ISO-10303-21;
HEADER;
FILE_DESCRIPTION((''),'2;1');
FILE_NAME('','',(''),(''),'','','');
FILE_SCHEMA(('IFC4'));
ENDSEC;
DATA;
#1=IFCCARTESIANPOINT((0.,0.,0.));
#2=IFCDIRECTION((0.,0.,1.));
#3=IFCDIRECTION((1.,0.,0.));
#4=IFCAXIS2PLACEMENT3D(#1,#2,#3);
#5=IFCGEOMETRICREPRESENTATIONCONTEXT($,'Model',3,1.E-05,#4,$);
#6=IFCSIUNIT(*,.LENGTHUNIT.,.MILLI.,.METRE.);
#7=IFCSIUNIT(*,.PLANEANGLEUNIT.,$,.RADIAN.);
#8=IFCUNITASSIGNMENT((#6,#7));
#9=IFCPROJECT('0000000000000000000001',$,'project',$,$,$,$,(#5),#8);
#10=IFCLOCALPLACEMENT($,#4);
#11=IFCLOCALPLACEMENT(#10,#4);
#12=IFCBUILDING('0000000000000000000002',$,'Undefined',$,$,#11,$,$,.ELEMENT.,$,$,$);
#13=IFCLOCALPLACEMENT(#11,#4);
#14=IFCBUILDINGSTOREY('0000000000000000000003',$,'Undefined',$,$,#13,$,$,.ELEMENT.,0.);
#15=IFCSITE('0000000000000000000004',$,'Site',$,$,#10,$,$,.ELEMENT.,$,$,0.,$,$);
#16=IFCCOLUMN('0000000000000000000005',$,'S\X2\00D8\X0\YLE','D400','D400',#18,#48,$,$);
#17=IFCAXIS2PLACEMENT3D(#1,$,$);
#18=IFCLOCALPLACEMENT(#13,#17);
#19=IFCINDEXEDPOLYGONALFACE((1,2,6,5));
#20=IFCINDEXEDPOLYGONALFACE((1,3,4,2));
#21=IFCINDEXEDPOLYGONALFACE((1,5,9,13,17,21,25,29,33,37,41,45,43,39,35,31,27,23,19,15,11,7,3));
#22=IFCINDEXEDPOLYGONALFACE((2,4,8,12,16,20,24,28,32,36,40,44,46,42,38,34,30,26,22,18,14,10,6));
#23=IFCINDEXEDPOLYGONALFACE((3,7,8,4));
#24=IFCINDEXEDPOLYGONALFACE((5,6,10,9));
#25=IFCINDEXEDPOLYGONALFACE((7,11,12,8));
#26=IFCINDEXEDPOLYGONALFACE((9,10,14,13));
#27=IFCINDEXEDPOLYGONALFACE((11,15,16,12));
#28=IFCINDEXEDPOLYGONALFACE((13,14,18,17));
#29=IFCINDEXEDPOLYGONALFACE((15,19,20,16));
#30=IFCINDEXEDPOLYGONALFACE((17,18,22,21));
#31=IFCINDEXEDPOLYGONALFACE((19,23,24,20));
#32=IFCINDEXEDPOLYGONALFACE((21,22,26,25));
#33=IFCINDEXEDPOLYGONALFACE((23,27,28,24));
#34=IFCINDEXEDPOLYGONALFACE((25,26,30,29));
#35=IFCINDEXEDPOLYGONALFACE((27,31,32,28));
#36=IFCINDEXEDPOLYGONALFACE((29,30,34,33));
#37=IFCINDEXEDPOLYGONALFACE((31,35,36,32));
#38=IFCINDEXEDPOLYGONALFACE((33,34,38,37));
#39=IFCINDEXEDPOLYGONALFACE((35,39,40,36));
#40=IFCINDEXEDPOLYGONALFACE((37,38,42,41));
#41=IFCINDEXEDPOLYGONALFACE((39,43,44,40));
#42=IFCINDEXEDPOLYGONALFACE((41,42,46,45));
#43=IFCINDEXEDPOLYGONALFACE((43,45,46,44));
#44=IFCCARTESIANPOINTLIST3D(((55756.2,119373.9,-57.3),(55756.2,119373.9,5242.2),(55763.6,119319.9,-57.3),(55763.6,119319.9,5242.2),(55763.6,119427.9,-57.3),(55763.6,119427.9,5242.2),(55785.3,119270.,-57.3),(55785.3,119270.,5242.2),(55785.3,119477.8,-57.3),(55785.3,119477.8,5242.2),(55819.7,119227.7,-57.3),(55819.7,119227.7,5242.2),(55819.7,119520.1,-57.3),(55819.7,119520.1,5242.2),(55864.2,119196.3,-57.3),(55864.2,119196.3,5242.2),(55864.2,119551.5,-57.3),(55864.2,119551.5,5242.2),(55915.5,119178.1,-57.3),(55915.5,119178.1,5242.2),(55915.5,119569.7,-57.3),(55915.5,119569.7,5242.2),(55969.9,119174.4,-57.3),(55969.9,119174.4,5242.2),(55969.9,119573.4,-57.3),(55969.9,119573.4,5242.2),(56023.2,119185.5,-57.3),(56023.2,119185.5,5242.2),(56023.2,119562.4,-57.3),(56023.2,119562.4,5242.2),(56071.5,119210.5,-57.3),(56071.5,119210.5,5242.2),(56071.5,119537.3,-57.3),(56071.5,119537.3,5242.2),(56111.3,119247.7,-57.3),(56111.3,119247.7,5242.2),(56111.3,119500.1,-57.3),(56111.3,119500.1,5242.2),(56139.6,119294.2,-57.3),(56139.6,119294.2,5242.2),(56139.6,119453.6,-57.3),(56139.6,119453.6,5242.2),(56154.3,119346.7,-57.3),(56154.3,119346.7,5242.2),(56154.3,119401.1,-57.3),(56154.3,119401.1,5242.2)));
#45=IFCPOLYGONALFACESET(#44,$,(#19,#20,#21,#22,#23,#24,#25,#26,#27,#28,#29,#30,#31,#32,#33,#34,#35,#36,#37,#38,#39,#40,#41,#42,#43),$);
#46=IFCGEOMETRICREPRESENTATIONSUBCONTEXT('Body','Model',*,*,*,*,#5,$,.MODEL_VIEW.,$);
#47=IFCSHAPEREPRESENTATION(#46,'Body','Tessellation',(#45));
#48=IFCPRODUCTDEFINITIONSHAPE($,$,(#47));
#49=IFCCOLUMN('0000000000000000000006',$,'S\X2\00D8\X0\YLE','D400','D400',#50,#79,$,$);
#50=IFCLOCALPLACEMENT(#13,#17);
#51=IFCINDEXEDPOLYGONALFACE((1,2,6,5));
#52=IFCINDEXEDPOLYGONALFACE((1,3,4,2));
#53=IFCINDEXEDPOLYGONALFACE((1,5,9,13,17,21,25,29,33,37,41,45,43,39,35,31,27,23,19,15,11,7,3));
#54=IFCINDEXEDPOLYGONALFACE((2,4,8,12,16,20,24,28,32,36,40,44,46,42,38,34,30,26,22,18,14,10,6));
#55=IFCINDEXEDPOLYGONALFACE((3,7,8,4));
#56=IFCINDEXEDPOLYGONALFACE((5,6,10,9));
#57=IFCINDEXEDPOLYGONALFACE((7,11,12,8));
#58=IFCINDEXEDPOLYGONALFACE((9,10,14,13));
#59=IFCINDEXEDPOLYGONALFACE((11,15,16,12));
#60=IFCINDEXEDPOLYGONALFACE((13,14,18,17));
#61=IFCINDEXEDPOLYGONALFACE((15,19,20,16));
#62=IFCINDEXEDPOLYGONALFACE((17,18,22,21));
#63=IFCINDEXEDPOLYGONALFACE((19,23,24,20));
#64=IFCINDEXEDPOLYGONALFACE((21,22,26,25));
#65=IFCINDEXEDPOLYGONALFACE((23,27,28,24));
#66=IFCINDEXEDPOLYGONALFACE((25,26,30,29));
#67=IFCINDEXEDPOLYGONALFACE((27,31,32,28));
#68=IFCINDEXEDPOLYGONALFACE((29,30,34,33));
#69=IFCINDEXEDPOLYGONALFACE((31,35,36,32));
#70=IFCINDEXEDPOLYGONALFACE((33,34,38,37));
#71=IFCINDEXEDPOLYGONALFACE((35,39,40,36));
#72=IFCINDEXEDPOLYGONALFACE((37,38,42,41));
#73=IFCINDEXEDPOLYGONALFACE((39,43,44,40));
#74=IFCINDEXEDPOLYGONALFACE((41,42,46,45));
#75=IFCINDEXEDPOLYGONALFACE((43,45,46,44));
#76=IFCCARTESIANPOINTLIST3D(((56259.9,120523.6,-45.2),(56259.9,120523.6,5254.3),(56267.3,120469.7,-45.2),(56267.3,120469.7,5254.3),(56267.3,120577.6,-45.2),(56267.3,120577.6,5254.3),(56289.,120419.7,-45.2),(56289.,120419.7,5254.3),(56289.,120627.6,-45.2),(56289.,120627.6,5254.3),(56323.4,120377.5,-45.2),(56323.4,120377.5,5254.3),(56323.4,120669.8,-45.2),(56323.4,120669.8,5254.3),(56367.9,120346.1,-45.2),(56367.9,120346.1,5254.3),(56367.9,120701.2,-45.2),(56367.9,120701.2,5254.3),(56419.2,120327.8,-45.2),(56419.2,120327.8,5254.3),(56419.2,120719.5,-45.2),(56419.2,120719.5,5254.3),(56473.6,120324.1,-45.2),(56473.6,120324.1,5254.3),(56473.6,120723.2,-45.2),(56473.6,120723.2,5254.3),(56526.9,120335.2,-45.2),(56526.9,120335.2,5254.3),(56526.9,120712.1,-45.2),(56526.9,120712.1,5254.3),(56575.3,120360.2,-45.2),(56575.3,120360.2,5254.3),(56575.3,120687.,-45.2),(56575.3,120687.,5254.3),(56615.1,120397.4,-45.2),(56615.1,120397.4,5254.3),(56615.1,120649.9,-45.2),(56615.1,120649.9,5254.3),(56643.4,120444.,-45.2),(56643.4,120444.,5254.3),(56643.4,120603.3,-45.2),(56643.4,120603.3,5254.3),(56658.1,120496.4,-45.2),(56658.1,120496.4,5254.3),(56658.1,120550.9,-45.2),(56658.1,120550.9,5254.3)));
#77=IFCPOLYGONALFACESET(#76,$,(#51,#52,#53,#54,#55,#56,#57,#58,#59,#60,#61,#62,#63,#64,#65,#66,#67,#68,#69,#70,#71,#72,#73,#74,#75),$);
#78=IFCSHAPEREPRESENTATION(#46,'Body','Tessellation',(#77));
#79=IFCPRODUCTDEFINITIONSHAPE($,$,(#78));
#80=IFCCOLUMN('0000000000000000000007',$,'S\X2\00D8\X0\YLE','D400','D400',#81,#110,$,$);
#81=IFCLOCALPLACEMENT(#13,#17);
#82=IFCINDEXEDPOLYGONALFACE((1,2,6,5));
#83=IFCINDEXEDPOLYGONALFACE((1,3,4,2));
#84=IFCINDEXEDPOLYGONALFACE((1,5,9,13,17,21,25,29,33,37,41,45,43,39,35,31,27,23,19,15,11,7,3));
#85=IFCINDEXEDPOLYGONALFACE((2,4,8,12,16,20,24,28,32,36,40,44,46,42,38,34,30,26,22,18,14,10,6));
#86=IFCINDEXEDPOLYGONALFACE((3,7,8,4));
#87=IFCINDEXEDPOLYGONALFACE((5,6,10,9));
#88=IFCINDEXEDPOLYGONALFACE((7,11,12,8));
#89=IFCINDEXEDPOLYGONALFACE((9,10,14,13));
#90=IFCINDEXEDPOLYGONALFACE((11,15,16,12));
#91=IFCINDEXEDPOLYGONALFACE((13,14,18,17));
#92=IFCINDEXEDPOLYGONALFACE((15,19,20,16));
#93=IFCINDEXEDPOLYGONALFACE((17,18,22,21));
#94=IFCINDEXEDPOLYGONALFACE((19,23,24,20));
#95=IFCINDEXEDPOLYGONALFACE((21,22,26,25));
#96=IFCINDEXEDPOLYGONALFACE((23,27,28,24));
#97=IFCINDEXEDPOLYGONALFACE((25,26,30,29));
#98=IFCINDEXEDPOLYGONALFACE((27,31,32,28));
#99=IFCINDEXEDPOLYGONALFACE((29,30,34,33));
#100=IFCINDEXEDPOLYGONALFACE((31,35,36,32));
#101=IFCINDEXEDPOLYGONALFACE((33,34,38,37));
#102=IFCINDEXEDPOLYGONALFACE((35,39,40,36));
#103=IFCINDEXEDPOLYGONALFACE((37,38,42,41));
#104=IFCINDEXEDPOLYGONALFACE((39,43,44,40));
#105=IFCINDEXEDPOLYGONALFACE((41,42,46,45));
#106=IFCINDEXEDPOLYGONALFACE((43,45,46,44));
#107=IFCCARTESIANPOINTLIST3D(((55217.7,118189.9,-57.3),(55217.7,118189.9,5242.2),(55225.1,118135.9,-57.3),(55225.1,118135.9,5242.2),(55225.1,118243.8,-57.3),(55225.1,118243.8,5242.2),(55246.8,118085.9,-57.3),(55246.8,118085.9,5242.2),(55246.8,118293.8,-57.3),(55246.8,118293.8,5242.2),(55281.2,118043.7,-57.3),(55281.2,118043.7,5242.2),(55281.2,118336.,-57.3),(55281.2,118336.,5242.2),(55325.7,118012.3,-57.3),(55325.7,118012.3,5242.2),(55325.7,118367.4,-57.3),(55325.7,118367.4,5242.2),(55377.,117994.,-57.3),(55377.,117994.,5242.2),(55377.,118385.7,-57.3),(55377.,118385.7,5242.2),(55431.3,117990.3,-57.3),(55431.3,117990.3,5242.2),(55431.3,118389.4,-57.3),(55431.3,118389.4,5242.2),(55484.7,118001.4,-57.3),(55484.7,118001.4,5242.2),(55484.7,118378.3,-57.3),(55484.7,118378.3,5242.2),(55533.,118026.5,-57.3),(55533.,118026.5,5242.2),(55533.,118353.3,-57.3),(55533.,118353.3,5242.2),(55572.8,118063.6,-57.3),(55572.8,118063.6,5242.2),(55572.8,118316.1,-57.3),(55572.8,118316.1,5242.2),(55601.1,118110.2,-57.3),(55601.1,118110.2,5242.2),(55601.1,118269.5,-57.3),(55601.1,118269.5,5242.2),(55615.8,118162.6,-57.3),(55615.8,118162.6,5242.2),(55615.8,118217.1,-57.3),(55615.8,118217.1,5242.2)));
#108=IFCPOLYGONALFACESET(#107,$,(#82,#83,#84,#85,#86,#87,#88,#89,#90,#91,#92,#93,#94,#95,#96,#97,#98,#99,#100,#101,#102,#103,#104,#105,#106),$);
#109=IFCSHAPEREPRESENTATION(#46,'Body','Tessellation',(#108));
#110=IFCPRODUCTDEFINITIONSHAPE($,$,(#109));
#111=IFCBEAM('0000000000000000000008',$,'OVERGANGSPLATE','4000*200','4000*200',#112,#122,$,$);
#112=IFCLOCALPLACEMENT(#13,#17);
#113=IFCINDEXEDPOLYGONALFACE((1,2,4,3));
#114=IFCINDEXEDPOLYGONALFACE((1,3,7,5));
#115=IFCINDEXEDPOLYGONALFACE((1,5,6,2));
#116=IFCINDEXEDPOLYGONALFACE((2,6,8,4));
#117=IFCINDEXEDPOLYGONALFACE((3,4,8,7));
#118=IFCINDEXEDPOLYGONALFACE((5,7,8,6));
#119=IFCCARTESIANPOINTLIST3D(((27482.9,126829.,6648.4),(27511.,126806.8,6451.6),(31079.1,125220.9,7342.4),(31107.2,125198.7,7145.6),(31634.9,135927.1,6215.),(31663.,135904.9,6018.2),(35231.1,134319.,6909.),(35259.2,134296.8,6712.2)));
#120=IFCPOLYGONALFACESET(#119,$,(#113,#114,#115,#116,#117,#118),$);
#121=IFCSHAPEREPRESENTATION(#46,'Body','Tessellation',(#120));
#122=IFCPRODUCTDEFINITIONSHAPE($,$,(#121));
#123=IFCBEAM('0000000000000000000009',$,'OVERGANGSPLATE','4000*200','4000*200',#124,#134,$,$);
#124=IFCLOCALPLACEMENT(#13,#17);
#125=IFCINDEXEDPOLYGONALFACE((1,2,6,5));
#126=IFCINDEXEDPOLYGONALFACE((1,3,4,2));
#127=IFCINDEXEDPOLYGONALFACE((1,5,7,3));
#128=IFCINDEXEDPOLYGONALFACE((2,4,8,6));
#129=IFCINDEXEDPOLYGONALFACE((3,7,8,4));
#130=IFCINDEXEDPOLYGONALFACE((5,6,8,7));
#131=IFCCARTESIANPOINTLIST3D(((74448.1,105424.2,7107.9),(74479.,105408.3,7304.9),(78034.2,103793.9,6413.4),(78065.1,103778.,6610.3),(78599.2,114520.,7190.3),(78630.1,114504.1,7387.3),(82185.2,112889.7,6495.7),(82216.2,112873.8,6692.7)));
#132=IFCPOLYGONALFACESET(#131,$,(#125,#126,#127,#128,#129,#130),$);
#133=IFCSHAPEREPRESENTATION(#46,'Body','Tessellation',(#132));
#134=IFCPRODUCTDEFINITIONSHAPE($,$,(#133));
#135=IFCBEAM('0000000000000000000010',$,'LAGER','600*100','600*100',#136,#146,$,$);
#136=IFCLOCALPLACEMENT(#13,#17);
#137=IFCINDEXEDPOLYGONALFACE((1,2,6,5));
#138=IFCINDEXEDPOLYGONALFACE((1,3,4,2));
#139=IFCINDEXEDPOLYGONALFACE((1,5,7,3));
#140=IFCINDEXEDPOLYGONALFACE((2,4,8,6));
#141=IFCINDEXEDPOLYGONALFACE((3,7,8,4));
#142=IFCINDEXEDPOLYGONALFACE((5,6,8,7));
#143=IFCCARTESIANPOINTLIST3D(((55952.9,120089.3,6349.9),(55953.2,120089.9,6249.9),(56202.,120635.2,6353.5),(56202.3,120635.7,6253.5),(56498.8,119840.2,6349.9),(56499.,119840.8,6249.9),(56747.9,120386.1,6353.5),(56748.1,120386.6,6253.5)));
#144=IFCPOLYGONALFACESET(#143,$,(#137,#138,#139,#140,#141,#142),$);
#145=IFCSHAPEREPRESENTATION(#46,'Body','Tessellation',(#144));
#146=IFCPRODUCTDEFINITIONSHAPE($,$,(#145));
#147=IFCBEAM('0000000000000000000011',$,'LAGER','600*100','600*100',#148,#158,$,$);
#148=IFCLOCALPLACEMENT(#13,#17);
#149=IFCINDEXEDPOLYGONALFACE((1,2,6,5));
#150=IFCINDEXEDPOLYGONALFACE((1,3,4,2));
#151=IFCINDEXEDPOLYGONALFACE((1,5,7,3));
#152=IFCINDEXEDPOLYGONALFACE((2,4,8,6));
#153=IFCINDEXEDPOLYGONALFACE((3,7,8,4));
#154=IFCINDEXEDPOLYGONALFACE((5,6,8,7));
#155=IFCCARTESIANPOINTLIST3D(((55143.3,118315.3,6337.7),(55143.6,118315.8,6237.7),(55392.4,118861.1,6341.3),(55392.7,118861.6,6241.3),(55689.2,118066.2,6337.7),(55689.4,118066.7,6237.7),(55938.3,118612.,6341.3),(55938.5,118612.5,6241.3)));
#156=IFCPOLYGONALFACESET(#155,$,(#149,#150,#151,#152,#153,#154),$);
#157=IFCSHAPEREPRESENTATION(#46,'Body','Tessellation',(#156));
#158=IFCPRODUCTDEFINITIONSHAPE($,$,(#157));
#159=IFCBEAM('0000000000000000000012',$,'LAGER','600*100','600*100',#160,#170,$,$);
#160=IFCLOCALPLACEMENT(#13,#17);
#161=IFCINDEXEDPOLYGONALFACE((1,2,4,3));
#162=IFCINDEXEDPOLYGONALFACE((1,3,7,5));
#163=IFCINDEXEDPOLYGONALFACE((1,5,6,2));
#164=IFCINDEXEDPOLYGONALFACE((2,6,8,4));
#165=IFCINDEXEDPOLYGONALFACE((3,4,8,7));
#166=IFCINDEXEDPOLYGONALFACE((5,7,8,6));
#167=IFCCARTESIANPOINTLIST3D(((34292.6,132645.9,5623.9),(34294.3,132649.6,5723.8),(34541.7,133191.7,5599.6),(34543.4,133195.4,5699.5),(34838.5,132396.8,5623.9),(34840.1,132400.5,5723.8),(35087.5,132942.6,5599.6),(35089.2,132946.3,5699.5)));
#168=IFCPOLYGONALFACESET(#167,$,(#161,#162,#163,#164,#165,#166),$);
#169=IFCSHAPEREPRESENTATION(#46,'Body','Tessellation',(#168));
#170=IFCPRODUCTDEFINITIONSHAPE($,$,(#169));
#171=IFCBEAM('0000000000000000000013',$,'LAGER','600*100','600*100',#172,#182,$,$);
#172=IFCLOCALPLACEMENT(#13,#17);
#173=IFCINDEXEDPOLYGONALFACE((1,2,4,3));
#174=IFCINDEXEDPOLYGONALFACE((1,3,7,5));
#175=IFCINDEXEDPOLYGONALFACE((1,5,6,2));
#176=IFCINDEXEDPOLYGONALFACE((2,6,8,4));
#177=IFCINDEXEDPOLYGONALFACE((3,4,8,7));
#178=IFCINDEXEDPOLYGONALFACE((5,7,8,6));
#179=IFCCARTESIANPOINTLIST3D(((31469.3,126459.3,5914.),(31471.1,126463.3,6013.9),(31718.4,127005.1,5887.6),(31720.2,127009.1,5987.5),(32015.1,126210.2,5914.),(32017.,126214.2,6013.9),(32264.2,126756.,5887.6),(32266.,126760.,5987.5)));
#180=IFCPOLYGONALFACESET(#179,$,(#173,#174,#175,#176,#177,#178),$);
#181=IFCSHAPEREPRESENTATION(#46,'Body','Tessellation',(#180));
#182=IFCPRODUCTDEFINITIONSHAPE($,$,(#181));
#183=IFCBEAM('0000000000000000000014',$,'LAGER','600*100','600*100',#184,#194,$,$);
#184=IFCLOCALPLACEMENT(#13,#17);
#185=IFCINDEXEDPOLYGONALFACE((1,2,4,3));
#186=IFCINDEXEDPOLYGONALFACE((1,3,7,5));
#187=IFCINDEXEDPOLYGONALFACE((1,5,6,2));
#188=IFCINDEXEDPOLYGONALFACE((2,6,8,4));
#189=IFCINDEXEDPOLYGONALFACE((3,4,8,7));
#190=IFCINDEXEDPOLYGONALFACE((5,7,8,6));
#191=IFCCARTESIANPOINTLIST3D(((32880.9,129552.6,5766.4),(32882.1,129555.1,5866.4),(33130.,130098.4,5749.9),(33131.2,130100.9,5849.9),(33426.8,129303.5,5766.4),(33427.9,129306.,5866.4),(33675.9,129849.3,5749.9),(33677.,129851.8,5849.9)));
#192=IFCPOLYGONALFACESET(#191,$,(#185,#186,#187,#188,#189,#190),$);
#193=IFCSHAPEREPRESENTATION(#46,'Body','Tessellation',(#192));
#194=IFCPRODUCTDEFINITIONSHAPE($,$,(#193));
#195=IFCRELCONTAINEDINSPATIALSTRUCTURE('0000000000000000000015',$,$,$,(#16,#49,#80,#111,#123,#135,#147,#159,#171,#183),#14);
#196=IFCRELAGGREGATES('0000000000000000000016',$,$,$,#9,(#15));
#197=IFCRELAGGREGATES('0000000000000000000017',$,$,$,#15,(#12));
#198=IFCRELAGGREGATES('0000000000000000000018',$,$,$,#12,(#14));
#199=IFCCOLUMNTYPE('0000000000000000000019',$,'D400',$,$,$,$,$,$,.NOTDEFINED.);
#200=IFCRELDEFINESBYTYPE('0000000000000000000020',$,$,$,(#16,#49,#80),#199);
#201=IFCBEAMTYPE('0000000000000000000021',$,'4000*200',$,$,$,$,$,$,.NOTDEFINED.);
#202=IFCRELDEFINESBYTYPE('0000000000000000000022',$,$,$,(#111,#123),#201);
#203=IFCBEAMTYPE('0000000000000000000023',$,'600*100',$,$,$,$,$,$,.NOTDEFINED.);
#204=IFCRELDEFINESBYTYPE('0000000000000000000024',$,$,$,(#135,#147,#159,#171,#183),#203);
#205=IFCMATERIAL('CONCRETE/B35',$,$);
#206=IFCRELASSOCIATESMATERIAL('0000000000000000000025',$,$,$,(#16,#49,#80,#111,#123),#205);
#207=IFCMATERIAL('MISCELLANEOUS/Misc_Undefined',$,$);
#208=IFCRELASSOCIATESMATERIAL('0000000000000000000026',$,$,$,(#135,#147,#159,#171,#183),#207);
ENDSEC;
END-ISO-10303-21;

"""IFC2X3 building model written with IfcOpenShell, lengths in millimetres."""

from ifc_helpers import new_model, si_unit, frame, frame_2d, origin_with_axes, place, context, subcontext, project, spatial, rectangle, circle, extrude, material, type_object, element, save


model = new_model("IFC2X3")

# Units and contexts
model_context = context("Model", 3, precision=1e-05, world=origin_with_axes())
body_context = subcontext(model_context, "Body", "Model", "MODEL_VIEW")
ifc_project = project(units=[si_unit("LENGTHUNIT", "METRE", prefix="MILLI"), si_unit("PLANEANGLEUNIT", "RADIAN")], contexts=[model_context])

# Site, building, storey
site_placement = place(None, origin_with_axes())
site = spatial("IfcSite", under=ifc_project, at=site_placement, Name="Site", CompositionType="ELEMENT", RefElevation=0.0)
building_placement = place(site_placement, origin_with_axes())
building = spatial("IfcBuilding", under=site, at=building_placement, Name="Undefined", CompositionType="ELEMENT")
storey_placement = place(building_placement, origin_with_axes())
storey = spatial("IfcBuildingStorey", under=building, at=storey_placement, Name="Undefined", CompositionType="ELEMENT", Elevation=0.0)

# Columns
ifc_material_1 = material(Name="CONCRETE/B35")
column_type = type_object("IfcColumnType", Name="D400", PredefinedType="NOTDEFINED")
for number, where, z_axis, x_axis, name in (
    (1, (55956.2, 119373.9, -57.3), (0.0, 0.0, 1.0), (0.0, 1.0, 0.0), "SØYLE"),
    (2, (56459.9, 120523.6, -45.2), (0.0, 0.0, 1.0), (0.0, 1.0, 0.0), "SØYLE"),
):
    element("IfcColumn", number, at=place(storey_placement, frame(where, z_axis=z_axis, x_axis=x_axis)), inside=storey, type_object=column_type, material=ifc_material_1, Name=name, Description="D400", ObjectType="D400", context=body_context, shape_type="SweptSolid", body=[
        extrude(circle(Radius=200.0, at=frame_2d((0.0, 0.0), x_axis=(1.0, 0.0))), frame((0.0, 0.0, 5299.5), z_axis=(0.0, 0.0, -1.0), x_axis=(0.0, 1.0, 0.0)), (0.0, 0.0, 1.0), 5299.5),
    ])
column_placement = place(storey_placement, frame((55417.7, 118189.9, -57.3), z_axis=(0.0, 0.0, 1.0), x_axis=(0.0, 1.0, 0.0)))
element("IfcColumn", 3, at=column_placement, inside=storey, type_object=column_type, material=ifc_material_1, Name="SØYLE", Description="D400", ObjectType="D400", context=body_context, shape_type="SweptSolid", body=[
    extrude(circle(Radius=200.0, at=frame_2d((0.0, 0.0), x_axis=(1.0, 0.0))), frame((0.0, 0.0, 5299.5), z_axis=(0.0, 0.0, -1.0), x_axis=(0.0, 1.0, 0.0)), (0.0, 0.0, 1.0), 5299.5),
])

# Beams
beam_type_1 = type_object("IfcBeamType", Name="4000*200", PredefinedType="NOTDEFINED")
beam_1_placement = place(storey_placement, frame((33447.1, 135111.9, 6463.6), z_axis=(0.899044, -0.402024, 0.173485), x_axis=(-0.414781, -0.90889, 0.043295)))
element("IfcBeam", 4, at=beam_1_placement, inside=storey, type_object=beam_type_1, material=ifc_material_1, Name="OVERGANGSPLATE", Description="4000*200", ObjectType="4000*200", context=body_context, shape_type="SweptSolid", body=[
    extrude(rectangle(XDim=200.0, YDim=4000.0, at=frame_2d((0.0, 0.0), x_axis=(1.0, 0.0))), frame((10010.1, 0.0, 0.0), z_axis=(-1.0, 0.0, 0.0), x_axis=(0.0, -1.0, 0.0)), (0.0, 0.0, 1.0), 10010.1),
])
beam_2_placement = place(storey_placement, frame((76256.6, 104601.1, 6859.1), z_axis=(-0.896512, 0.407571, 0.173642), x_axis=(0.415166, 0.909708, 0.008239)))
element("IfcBeam", 5, at=beam_2_placement, inside=storey, type_object=beam_type_1, material=ifc_material_1, Name="OVERGANGSPLATE", Description="4000*200", ObjectType="4000*200", context=body_context, shape_type="SweptSolid", body=[
    extrude(rectangle(XDim=200.0, YDim=4000.0, at=frame_2d((0.0, 0.0), x_axis=(1.0, 0.0))), frame((9998.6, 0.0, 0.0), z_axis=(-1.0, 0.0, 0.0), x_axis=(0.0, -1.0, 0.0)), (0.0, 0.0, 1.0), 9998.6),
])
ifc_material_2 = material(Name="MISCELLANEOUS/Misc_Undefined")
beam_type_2 = type_object("IfcBeamType", Name="600*100", PredefinedType="NOTDEFINED")
for number, where, z_axis, x_axis, name in (
    (6, (56226.0, 119965.0, 6299.9), (-0.90975, 0.415157, 0.0), (0.41515, 0.909734, 0.005889), "LAGER"),
    (7, (55416.4, 118191.0, 6287.7), (-0.90975, 0.415157, 0.0), (0.41515, 0.909734, 0.005889), "LAGER"),
):
    element("IfcBeam", number, at=place(storey_placement, frame(where, z_axis=z_axis, x_axis=x_axis)), inside=storey, type_object=beam_type_2, material=ifc_material_2, Name=name, Description="600*100", ObjectType="600*100", context=body_context, shape_type="SweptSolid", body=[
        extrude(rectangle(XDim=100.0, YDim=600.0, at=frame_2d((0.0, 0.0), x_axis=(1.0, 0.0))), frame((600.0, 0.0, 0.0), z_axis=(-1.0, 0.0, 0.0), x_axis=(0.0, -1.0, 0.0)), (0.0, 0.0, 1.0), 600.0),
    ])
beam_3_placement = place(storey_placement, frame((34566.4, 132523.2, 5673.9), z_axis=(-0.90975, 0.415157, 0.0), x_axis=(0.414817, 0.909004, -0.040476)))
element("IfcBeam", 8, at=beam_3_placement, inside=storey, type_object=beam_type_2, material=ifc_material_2, Name="LAGER", Description="600*100", ObjectType="600*100", context=body_context, shape_type="SweptSolid", body=[
    extrude(rectangle(XDim=100.0, YDim=600.0, at=frame_2d((0.0, 0.0), x_axis=(1.0, 0.0))), frame((600.5, 0.0, 0.0), z_axis=(-1.0, 0.0, 0.0), x_axis=(0.0, -1.0, 0.0)), (0.0, 0.0, 1.0), 600.5),
])
beam_4_placement = place(storey_placement, frame((31743.1, 126336.7, 5963.9), z_axis=(-0.90975, 0.415157, 0.0), x_axis=(0.414758, 0.908875, -0.043844)))
element("IfcBeam", 9, at=beam_4_placement, inside=storey, type_object=beam_type_2, material=ifc_material_2, Name="LAGER", Description="600*100", ObjectType="600*100", context=body_context, shape_type="SweptSolid", body=[
    extrude(rectangle(XDim=100.0, YDim=600.0, at=frame_2d((0.0, 0.0), x_axis=(1.0, 0.0))), frame((600.6, 0.0, 0.0), z_axis=(-1.0, 0.0, 0.0), x_axis=(0.0, -1.0, 0.0)), (0.0, 0.0, 1.0), 600.6),
])
beam_5_placement = place(storey_placement, frame((33154.4, 129429.3, 5816.4), z_axis=(-0.90975, 0.415157, 0.0), x_axis=(0.415001, 0.909407, -0.027434)))
element("IfcBeam", 10, at=beam_5_placement, inside=storey, type_object=beam_type_2, material=ifc_material_2, Name="LAGER", Description="600*100", ObjectType="600*100", context=body_context, shape_type="SweptSolid", body=[
    extrude(rectangle(XDim=100.0, YDim=600.0, at=frame_2d((0.0, 0.0), x_axis=(1.0, 0.0))), frame((600.2, 0.0, 0.0), z_axis=(-1.0, 0.0, 0.0), x_axis=(0.0, -1.0, 0.0)), (0.0, 0.0, 1.0), 600.2),
])

save(model, "model.ifc")
